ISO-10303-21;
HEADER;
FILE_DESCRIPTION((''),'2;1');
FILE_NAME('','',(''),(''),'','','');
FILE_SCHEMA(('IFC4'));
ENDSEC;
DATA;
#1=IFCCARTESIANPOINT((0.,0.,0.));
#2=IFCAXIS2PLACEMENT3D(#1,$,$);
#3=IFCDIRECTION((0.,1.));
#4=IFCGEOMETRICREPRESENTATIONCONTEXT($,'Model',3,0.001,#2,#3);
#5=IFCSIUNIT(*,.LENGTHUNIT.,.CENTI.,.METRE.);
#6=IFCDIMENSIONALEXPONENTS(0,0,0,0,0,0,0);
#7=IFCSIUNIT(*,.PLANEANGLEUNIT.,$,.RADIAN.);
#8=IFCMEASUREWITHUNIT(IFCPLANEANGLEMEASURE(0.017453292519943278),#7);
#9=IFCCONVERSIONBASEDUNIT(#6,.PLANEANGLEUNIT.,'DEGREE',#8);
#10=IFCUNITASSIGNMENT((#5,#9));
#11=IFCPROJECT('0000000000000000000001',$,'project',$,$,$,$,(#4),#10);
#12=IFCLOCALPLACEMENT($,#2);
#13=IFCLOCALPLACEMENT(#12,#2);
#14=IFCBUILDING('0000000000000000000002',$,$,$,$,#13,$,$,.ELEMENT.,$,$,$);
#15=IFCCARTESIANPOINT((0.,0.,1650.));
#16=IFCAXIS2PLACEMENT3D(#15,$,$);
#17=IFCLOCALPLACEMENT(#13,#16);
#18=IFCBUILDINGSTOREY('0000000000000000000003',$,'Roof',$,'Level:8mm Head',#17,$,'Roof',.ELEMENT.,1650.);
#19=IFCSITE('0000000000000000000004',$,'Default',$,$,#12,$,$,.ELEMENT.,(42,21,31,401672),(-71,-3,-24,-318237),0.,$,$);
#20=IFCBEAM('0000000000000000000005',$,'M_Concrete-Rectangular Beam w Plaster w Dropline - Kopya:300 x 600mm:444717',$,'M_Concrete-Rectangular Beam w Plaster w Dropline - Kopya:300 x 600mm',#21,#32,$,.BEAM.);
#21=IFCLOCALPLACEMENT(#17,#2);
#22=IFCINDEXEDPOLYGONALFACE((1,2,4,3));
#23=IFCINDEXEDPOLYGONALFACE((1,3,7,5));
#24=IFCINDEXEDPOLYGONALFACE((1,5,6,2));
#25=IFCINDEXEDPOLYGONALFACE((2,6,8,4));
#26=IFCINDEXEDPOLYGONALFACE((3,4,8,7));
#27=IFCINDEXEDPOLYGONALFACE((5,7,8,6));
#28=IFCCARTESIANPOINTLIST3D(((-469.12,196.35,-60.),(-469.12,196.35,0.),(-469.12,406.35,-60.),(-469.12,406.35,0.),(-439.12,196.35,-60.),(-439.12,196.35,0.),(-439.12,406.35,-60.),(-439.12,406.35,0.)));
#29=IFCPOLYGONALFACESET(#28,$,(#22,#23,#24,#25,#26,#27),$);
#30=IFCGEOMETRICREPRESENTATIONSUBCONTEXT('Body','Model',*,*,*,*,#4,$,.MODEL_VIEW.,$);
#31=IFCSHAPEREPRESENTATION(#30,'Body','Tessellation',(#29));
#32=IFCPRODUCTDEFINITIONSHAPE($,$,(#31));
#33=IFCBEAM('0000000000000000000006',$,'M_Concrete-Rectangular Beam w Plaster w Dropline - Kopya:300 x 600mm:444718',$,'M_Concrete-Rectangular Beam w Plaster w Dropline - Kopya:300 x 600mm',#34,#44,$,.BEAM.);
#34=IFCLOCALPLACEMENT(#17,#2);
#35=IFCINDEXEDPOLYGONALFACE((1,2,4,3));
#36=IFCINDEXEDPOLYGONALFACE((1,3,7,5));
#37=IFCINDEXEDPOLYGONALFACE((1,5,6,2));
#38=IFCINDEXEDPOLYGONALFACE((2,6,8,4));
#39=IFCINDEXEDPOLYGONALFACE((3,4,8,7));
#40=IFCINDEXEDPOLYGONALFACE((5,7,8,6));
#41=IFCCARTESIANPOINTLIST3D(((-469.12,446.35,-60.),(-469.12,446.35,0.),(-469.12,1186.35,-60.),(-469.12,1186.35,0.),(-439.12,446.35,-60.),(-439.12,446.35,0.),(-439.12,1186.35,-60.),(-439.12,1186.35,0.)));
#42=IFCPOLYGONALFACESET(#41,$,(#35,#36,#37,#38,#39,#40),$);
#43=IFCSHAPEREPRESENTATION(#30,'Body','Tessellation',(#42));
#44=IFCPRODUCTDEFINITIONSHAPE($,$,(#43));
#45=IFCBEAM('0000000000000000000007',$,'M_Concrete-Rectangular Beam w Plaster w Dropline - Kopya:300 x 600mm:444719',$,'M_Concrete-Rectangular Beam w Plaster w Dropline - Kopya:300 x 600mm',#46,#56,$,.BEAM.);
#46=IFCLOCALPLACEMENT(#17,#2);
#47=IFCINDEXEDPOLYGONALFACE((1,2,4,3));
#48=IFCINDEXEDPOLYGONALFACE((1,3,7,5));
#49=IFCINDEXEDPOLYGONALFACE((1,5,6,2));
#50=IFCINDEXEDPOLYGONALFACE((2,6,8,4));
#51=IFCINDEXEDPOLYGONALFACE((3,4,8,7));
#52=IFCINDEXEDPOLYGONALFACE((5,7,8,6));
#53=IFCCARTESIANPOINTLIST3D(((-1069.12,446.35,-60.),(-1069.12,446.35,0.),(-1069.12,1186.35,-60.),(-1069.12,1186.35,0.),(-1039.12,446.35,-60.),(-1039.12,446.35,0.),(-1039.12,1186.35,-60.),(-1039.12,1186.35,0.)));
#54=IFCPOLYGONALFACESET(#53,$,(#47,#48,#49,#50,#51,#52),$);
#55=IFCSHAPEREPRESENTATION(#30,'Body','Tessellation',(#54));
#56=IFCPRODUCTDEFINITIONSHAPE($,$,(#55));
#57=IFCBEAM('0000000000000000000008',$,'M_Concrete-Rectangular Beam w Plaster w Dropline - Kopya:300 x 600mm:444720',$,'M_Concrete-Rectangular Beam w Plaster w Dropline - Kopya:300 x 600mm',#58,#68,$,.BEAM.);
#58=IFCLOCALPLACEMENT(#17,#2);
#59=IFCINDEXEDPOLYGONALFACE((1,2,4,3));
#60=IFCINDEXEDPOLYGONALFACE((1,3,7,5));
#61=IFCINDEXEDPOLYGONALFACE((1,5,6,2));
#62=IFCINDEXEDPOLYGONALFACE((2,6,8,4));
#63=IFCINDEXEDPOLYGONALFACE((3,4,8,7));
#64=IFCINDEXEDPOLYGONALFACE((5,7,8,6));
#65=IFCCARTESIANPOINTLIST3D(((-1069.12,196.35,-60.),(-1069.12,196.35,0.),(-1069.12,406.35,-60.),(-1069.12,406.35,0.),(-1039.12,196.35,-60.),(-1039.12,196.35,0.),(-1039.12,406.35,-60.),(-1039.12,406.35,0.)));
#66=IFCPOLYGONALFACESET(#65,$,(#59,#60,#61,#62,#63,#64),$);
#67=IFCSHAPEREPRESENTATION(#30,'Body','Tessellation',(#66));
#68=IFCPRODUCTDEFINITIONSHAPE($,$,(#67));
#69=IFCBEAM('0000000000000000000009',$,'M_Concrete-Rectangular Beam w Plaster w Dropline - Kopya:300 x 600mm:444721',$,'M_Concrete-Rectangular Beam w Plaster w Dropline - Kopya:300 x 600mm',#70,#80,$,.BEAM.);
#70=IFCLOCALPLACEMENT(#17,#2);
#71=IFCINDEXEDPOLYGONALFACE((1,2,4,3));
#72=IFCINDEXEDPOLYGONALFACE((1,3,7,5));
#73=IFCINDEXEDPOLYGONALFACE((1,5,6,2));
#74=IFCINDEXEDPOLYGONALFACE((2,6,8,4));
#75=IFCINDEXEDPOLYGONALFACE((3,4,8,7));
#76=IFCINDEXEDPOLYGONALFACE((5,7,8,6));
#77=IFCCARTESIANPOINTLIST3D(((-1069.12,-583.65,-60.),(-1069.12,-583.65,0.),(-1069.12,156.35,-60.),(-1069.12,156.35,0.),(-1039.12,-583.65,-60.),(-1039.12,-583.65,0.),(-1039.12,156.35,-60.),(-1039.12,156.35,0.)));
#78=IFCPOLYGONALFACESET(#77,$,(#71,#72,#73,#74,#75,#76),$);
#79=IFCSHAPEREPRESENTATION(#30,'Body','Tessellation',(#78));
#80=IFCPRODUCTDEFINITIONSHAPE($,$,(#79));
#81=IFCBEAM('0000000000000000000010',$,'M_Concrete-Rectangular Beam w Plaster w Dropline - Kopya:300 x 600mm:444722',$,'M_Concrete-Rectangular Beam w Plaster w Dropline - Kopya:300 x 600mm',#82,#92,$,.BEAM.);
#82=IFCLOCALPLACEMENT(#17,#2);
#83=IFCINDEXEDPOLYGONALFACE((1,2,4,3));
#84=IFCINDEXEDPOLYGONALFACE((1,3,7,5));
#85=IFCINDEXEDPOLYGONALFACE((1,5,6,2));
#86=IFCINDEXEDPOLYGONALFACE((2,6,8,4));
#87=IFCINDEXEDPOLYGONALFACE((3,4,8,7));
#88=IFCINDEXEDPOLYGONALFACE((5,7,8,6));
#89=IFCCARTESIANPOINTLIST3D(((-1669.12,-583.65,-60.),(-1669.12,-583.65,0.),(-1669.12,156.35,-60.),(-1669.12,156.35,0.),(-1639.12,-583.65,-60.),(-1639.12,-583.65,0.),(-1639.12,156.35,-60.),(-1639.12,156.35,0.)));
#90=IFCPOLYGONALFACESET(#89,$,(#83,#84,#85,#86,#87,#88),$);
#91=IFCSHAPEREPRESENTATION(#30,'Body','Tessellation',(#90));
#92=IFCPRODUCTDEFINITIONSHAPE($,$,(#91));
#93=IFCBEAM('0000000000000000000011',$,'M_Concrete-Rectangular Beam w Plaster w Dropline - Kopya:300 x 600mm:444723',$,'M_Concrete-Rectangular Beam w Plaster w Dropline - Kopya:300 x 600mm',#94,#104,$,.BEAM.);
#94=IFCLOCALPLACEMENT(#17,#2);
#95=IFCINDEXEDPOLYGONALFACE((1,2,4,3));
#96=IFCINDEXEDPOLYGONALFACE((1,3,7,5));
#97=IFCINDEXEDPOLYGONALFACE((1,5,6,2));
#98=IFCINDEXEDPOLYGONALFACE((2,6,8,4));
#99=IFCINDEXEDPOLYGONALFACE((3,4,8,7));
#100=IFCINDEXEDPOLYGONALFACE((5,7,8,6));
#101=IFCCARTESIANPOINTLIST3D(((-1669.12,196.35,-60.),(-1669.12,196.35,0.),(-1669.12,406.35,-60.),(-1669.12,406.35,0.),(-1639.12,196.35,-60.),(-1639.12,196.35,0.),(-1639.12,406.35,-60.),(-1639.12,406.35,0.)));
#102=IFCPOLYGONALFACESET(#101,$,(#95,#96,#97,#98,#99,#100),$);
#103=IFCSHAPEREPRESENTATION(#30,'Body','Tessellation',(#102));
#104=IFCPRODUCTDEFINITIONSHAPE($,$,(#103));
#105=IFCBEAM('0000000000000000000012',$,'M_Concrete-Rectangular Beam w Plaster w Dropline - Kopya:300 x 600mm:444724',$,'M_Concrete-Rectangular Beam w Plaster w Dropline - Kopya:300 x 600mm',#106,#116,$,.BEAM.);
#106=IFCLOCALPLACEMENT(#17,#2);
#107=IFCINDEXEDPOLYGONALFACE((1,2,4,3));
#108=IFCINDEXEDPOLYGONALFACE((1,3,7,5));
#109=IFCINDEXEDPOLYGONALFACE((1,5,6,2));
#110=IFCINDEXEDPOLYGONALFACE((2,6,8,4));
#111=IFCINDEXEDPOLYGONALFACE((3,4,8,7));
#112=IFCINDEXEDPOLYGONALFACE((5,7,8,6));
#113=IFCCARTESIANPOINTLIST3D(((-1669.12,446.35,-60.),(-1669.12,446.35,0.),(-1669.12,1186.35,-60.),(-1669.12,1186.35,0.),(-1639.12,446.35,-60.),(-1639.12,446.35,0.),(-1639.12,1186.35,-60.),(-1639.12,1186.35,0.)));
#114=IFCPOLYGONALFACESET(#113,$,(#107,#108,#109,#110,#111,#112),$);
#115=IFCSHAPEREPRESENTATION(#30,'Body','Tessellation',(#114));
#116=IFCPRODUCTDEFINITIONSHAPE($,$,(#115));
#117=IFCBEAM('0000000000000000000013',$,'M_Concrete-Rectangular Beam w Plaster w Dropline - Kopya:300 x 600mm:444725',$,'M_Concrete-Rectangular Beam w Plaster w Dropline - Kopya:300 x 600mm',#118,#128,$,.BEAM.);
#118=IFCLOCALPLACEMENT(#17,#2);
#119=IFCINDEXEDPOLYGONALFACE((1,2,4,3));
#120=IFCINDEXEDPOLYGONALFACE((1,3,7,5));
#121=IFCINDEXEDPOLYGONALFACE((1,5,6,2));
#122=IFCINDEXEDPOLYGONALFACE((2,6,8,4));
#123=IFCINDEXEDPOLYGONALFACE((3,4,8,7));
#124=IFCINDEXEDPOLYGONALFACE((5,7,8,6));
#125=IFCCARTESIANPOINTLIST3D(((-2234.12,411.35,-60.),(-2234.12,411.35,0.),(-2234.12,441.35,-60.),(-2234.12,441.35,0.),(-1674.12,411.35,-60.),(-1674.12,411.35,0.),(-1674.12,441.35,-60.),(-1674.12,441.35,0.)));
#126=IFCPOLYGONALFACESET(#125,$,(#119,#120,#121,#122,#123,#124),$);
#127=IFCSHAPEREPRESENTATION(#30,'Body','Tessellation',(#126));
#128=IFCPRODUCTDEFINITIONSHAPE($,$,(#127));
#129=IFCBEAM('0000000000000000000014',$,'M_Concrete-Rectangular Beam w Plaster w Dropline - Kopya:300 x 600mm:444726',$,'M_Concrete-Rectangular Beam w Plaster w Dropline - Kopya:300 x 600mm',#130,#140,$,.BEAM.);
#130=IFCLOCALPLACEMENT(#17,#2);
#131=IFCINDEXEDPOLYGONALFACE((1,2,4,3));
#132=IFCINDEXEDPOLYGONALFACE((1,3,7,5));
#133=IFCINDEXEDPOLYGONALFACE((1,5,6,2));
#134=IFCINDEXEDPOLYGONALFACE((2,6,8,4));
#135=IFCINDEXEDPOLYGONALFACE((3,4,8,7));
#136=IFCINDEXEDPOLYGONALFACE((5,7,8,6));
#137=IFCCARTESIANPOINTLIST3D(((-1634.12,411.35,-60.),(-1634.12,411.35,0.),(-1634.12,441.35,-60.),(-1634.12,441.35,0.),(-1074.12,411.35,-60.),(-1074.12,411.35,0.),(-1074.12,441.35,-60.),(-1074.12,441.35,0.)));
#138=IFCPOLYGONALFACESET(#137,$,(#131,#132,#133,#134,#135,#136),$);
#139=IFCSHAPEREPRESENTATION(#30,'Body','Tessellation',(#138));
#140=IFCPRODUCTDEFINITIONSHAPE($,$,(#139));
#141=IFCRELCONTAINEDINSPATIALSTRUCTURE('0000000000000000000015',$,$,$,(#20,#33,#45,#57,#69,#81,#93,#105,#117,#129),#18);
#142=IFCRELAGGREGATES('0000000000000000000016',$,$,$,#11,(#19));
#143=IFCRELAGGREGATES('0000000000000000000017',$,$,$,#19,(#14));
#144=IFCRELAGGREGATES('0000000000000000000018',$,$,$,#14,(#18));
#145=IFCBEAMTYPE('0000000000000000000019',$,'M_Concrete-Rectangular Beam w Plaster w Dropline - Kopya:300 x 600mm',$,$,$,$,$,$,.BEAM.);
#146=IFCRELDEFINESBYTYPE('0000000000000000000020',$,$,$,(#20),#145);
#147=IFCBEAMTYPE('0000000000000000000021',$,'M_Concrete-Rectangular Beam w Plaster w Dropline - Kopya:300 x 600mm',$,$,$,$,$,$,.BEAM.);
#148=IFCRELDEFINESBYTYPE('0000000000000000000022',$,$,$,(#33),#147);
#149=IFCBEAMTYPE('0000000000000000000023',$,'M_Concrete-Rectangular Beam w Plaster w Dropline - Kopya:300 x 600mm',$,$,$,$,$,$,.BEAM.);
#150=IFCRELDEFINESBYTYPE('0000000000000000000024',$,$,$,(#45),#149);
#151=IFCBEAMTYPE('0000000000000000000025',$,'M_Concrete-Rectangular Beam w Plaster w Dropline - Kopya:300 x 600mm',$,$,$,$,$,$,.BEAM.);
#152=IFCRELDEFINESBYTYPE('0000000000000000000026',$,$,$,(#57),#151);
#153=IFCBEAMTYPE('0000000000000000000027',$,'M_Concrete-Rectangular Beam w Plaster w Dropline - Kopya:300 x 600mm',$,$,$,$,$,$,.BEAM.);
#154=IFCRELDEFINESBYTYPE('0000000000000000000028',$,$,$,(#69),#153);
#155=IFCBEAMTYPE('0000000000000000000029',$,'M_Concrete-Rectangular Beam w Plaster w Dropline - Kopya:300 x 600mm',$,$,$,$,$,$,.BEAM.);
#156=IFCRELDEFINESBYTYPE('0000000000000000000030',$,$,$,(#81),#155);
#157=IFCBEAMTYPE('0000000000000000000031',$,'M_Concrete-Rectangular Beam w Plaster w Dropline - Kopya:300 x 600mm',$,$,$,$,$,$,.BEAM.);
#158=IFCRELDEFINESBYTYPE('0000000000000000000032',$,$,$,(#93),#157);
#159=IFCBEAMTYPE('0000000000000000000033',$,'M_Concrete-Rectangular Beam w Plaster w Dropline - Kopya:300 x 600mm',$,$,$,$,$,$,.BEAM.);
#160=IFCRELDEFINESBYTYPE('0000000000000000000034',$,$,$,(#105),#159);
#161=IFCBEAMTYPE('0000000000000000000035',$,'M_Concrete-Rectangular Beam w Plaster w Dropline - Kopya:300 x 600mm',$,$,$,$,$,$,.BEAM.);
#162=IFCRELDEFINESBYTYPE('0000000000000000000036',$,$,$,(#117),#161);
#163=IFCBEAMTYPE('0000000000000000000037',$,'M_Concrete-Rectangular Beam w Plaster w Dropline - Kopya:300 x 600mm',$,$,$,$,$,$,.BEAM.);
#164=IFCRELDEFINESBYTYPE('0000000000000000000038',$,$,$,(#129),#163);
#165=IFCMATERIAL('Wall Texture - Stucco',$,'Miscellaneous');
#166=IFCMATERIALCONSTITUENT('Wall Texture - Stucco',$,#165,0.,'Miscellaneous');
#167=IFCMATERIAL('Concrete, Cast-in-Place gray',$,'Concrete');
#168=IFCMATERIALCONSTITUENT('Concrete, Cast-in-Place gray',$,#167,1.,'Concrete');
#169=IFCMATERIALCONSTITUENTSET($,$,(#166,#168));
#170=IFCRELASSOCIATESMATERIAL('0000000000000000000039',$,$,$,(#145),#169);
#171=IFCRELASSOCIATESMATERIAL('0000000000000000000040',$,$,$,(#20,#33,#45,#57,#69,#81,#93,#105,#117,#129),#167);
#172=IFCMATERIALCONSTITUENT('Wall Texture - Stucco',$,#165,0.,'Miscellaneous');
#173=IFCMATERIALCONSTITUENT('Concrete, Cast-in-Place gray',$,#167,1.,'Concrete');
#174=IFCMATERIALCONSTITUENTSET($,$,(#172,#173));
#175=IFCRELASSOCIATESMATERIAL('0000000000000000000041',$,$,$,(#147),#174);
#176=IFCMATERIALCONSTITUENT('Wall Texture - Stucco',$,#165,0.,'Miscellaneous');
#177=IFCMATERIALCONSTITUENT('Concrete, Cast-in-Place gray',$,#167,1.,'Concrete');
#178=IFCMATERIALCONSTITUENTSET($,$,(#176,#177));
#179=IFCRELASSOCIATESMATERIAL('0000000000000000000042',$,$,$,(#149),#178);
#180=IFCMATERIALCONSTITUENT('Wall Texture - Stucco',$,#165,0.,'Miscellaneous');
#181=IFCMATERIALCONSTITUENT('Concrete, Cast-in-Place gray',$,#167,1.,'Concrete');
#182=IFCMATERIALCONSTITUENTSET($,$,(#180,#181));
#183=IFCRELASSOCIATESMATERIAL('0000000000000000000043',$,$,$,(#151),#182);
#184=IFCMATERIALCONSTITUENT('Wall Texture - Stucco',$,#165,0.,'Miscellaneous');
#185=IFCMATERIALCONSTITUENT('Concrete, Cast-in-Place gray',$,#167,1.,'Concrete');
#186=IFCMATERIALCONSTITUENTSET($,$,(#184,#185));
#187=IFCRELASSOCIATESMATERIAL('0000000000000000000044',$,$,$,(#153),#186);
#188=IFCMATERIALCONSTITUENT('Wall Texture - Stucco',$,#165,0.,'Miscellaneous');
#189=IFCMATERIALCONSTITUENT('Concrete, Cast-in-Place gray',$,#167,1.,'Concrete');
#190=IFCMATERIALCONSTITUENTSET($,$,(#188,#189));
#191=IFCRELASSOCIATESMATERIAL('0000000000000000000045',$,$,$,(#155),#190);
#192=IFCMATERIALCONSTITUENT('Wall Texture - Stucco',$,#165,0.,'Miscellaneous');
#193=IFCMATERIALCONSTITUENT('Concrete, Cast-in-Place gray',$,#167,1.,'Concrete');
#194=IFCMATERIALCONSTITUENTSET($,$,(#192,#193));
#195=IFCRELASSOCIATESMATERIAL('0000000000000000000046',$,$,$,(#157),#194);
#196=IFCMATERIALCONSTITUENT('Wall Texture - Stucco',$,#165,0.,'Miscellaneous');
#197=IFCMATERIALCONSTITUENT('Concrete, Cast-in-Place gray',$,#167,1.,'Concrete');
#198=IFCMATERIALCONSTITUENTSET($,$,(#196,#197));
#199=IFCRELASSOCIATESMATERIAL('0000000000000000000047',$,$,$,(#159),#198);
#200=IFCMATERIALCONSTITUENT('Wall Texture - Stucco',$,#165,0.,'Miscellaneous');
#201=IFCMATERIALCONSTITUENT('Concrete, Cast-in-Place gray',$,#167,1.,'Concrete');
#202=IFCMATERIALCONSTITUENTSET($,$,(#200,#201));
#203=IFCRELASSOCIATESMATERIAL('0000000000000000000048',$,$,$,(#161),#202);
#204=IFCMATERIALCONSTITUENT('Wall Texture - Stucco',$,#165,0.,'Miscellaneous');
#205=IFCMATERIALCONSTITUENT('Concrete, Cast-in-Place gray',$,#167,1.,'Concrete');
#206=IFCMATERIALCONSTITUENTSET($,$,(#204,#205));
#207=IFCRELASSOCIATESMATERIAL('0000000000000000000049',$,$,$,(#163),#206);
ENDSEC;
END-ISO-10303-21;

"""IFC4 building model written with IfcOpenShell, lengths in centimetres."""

from ifc_helpers import new_model, entity, si_unit, converted_unit, direction, frame, origin, place, context, subcontext, project, spatial, indexed_curve, outline, extrude, source, transform, mapped, material, constituent, constituent_set, type_object, type_shapes, element, save


model = new_model("IFC4")

# Units and contexts
model_context = context("Model", 3, precision=0.001, world=origin(), true_north=direction((0.0, 1.0)))
body_context = subcontext(model_context, "Body", "Model", "MODEL_VIEW")
ifc_project = project(units=[si_unit("LENGTHUNIT", "METRE", prefix="CENTI"), converted_unit("PLANEANGLEUNIT", "DEGREE", entity("IfcPlaneAngleMeasure", 0.017453292519943278), si_unit("PLANEANGLEUNIT", "RADIAN"), dimensions=[0, 0, 0, 0, 0, 0, 0])], contexts=[model_context])

# Site, building, storey
site_placement = place(None, origin())
site = spatial("IfcSite", under=ifc_project, at=site_placement, Name="Default", CompositionType="ELEMENT", RefLatitude=(42, 21, 31, 401672), RefLongitude=(-71, -3, -24, -318237), RefElevation=0.0)
building_placement = place(site_placement, origin())
building = spatial("IfcBuilding", under=site, at=building_placement, CompositionType="ELEMENT")
storey_placement = place(building_placement, frame((0.0, 0.0, 1650.0)))
storey = spatial("IfcBuildingStorey", under=building, at=storey_placement, Name="Roof", ObjectType="Level:8mm Head", LongName="Roof", CompositionType="ELEMENT", Elevation=1650.0)

# Beams
ifc_material_1 = material(Name="Concrete, Cast-in-Place gray", Category="Concrete")
ifc_material_2 = material(Name="Wall Texture - Stucco", Category="Miscellaneous")
ifc_constituent_1 = constituent(ifc_material_2, Name="Wall Texture - Stucco", Category="Miscellaneous", fraction=0.0)
ifc_constituent_2 = constituent(ifc_material_1, Name="Concrete, Cast-in-Place gray", Category="Concrete", fraction=1.0)
ifc_constituent_set_1 = constituent_set(constituents=[ifc_constituent_1, ifc_constituent_2])
beam_type_1 = type_object("IfcBeamType", Name="M_Concrete-Rectangular Beam w Plaster w Dropline - Kopya:300 x 600mm", PredefinedType="BEAM", material=ifc_constituent_set_1)
shared_shape_1 = source(origin(), body_context, "Body", "SweptSolid", [
    extrude(outline(indexed_curve([(-15.0, -30.0), (15.0, -30.0), (15.0, 30.0), (-15.0, 30.0), (-15.0, -30.0)], self_intersect=False)), frame((-454.12, 196.35, 1620.0), z_axis=(0.0, 1.0, 0.0), x_axis=(-1.0, 0.0, 0.0)), (0.0, 0.0, 1.0), 210.0),
])
type_shapes(beam_type_1, [shared_shape_1])
beam_1_placement = place(storey_placement, frame((0.0, 0.0, -1650.0)))
element("IfcBeam", 1, at=beam_1_placement, inside=storey, type_object=beam_type_1, material=ifc_material_1, Name="M_Concrete-Rectangular Beam w Plaster w Dropline - Kopya:300 x 600mm:444717", ObjectType="M_Concrete-Rectangular Beam w Plaster w Dropline - Kopya:300 x 600mm", PredefinedType="BEAM", context=body_context, shape_type="MappedRepresentation", body=[
    mapped(shared_shape_1, transform((0.0, 0.0, 0.0), scale=1.0)),
])
ifc_constituent_3 = constituent(ifc_material_2, Name="Wall Texture - Stucco", Category="Miscellaneous", fraction=0.0)
ifc_constituent_4 = constituent(ifc_material_1, Name="Concrete, Cast-in-Place gray", Category="Concrete", fraction=1.0)
ifc_constituent_set_2 = constituent_set(constituents=[ifc_constituent_3, ifc_constituent_4])
beam_type_2 = type_object("IfcBeamType", Name="M_Concrete-Rectangular Beam w Plaster w Dropline - Kopya:300 x 600mm", PredefinedType="BEAM", material=ifc_constituent_set_2)
shared_shape_2 = source(origin(), body_context, "Body", "SweptSolid", [
    extrude(outline(indexed_curve([(-15.0, -30.0), (15.0, -30.0), (15.0, 30.0), (-15.0, 30.0), (-15.0, -30.0)], self_intersect=False)), frame((-454.12, 446.35, 1620.0), z_axis=(0.0, 1.0, 0.0), x_axis=(-1.0, 0.0, 0.0)), (0.0, 0.0, 1.0), 740.0),
])
type_shapes(beam_type_2, [shared_shape_2])
beam_2_placement = place(storey_placement, frame((0.0, 0.0, -1650.0)))
element("IfcBeam", 2, at=beam_2_placement, inside=storey, type_object=beam_type_2, material=ifc_material_1, Name="M_Concrete-Rectangular Beam w Plaster w Dropline - Kopya:300 x 600mm:444718", ObjectType="M_Concrete-Rectangular Beam w Plaster w Dropline - Kopya:300 x 600mm", PredefinedType="BEAM", context=body_context, shape_type="MappedRepresentation", body=[
    mapped(shared_shape_2, transform((0.0, 0.0, 0.0), scale=1.0)),
])
ifc_constituent_5 = constituent(ifc_material_2, Name="Wall Texture - Stucco", Category="Miscellaneous", fraction=0.0)
ifc_constituent_6 = constituent(ifc_material_1, Name="Concrete, Cast-in-Place gray", Category="Concrete", fraction=1.0)
ifc_constituent_set_3 = constituent_set(constituents=[ifc_constituent_5, ifc_constituent_6])
beam_type_3 = type_object("IfcBeamType", Name="M_Concrete-Rectangular Beam w Plaster w Dropline - Kopya:300 x 600mm", PredefinedType="BEAM", material=ifc_constituent_set_3)
shared_shape_3 = source(origin(), body_context, "Body", "SweptSolid", [
    extrude(outline(indexed_curve([(-15.0, -30.0), (15.0, -30.0), (15.0, 30.0), (-15.0, 30.0), (-15.0, -30.0)], self_intersect=False)), frame((-1054.12, 1186.35, 1620.0), z_axis=(0.0, -1.0, 0.0), x_axis=(-1.0, 0.0, 0.0)), (0.0, 0.0, 1.0), 740.0),
])
type_shapes(beam_type_3, [shared_shape_3])
beam_3_placement = place(storey_placement, frame((0.0, 0.0, -1650.0)))
element("IfcBeam", 3, at=beam_3_placement, inside=storey, type_object=beam_type_3, material=ifc_material_1, Name="M_Concrete-Rectangular Beam w Plaster w Dropline - Kopya:300 x 600mm:444719", ObjectType="M_Concrete-Rectangular Beam w Plaster w Dropline - Kopya:300 x 600mm", PredefinedType="BEAM", context=body_context, shape_type="MappedRepresentation", body=[
    mapped(shared_shape_3, transform((0.0, 0.0, 0.0), scale=1.0)),
])
ifc_constituent_7 = constituent(ifc_material_2, Name="Wall Texture - Stucco", Category="Miscellaneous", fraction=0.0)
ifc_constituent_8 = constituent(ifc_material_1, Name="Concrete, Cast-in-Place gray", Category="Concrete", fraction=1.0)
ifc_constituent_set_4 = constituent_set(constituents=[ifc_constituent_7, ifc_constituent_8])
beam_type_4 = type_object("IfcBeamType", Name="M_Concrete-Rectangular Beam w Plaster w Dropline - Kopya:300 x 600mm", PredefinedType="BEAM", material=ifc_constituent_set_4)
shared_shape_4 = source(origin(), body_context, "Body", "SweptSolid", [
    extrude(outline(indexed_curve([(-15.0, -30.0), (15.0, -30.0), (15.0, 30.0), (-15.0, 30.0), (-15.0, -30.0)], self_intersect=False)), frame((-1054.12, 406.35, 1620.0), z_axis=(0.0, -1.0, 0.0), x_axis=(-1.0, 0.0, 0.0)), (0.0, 0.0, 1.0), 210.0),
])
type_shapes(beam_type_4, [shared_shape_4])
beam_4_placement = place(storey_placement, frame((0.0, 0.0, -1650.0)))
element("IfcBeam", 4, at=beam_4_placement, inside=storey, type_object=beam_type_4, material=ifc_material_1, Name="M_Concrete-Rectangular Beam w Plaster w Dropline - Kopya:300 x 600mm:444720", ObjectType="M_Concrete-Rectangular Beam w Plaster w Dropline - Kopya:300 x 600mm", PredefinedType="BEAM", context=body_context, shape_type="MappedRepresentation", body=[
    mapped(shared_shape_4, transform((0.0, 0.0, 0.0), scale=1.0)),
])
ifc_constituent_9 = constituent(ifc_material_2, Name="Wall Texture - Stucco", Category="Miscellaneous", fraction=0.0)
ifc_constituent_10 = constituent(ifc_material_1, Name="Concrete, Cast-in-Place gray", Category="Concrete", fraction=1.0)
ifc_constituent_set_5 = constituent_set(constituents=[ifc_constituent_9, ifc_constituent_10])
beam_type_5 = type_object("IfcBeamType", Name="M_Concrete-Rectangular Beam w Plaster w Dropline - Kopya:300 x 600mm", PredefinedType="BEAM", material=ifc_constituent_set_5)
shared_shape_5 = source(origin(), body_context, "Body", "SweptSolid", [
    extrude(outline(indexed_curve([(-15.0, -30.0), (15.0, -30.0), (15.0, 30.0), (-15.0, 30.0), (-15.0, -30.0)], self_intersect=False)), frame((-1054.12, 156.35, 1620.0), z_axis=(0.0, -1.0, 0.0), x_axis=(-1.0, 0.0, 0.0)), (0.0, 0.0, 1.0), 740.0),
])
type_shapes(beam_type_5, [shared_shape_5])
beam_5_placement = place(storey_placement, frame((0.0, 0.0, -1650.0)))
element("IfcBeam", 5, at=beam_5_placement, inside=storey, type_object=beam_type_5, material=ifc_material_1, Name="M_Concrete-Rectangular Beam w Plaster w Dropline - Kopya:300 x 600mm:444721", ObjectType="M_Concrete-Rectangular Beam w Plaster w Dropline - Kopya:300 x 600mm", PredefinedType="BEAM", context=body_context, shape_type="MappedRepresentation", body=[
    mapped(shared_shape_5, transform((0.0, 0.0, 0.0), scale=1.0)),
])
ifc_constituent_11 = constituent(ifc_material_2, Name="Wall Texture - Stucco", Category="Miscellaneous", fraction=0.0)
ifc_constituent_12 = constituent(ifc_material_1, Name="Concrete, Cast-in-Place gray", Category="Concrete", fraction=1.0)
ifc_constituent_set_6 = constituent_set(constituents=[ifc_constituent_11, ifc_constituent_12])
beam_type_6 = type_object("IfcBeamType", Name="M_Concrete-Rectangular Beam w Plaster w Dropline - Kopya:300 x 600mm", PredefinedType="BEAM", material=ifc_constituent_set_6)
shared_shape_6 = source(origin(), body_context, "Body", "SweptSolid", [
    extrude(outline(indexed_curve([(-15.0, -30.0), (15.0, -30.0), (15.0, 30.0), (-15.0, 30.0), (-15.0, -30.0)], self_intersect=False)), frame((-1654.12, -583.65, 1620.0), z_axis=(0.0, 1.0, 0.0), x_axis=(-1.0, 0.0, 0.0)), (0.0, 0.0, 1.0), 740.0),
])
type_shapes(beam_type_6, [shared_shape_6])
beam_6_placement = place(storey_placement, frame((0.0, 0.0, -1650.0)))
element("IfcBeam", 6, at=beam_6_placement, inside=storey, type_object=beam_type_6, material=ifc_material_1, Name="M_Concrete-Rectangular Beam w Plaster w Dropline - Kopya:300 x 600mm:444722", ObjectType="M_Concrete-Rectangular Beam w Plaster w Dropline - Kopya:300 x 600mm", PredefinedType="BEAM", context=body_context, shape_type="MappedRepresentation", body=[
    mapped(shared_shape_6, transform((0.0, 0.0, 0.0), scale=1.0)),
])
ifc_constituent_13 = constituent(ifc_material_2, Name="Wall Texture - Stucco", Category="Miscellaneous", fraction=0.0)
ifc_constituent_14 = constituent(ifc_material_1, Name="Concrete, Cast-in-Place gray", Category="Concrete", fraction=1.0)
ifc_constituent_set_7 = constituent_set(constituents=[ifc_constituent_13, ifc_constituent_14])
beam_type_7 = type_object("IfcBeamType", Name="M_Concrete-Rectangular Beam w Plaster w Dropline - Kopya:300 x 600mm", PredefinedType="BEAM", material=ifc_constituent_set_7)
shared_shape_7 = source(origin(), body_context, "Body", "SweptSolid", [
    extrude(outline(indexed_curve([(-15.0, -30.0), (15.0, -30.0), (15.0, 30.0), (-15.0, 30.0), (-15.0, -30.0)], self_intersect=False)), frame((-1654.12, 196.35, 1620.0), z_axis=(0.0, 1.0, 0.0), x_axis=(-1.0, 0.0, 0.0)), (0.0, 0.0, 1.0), 210.0),
])
type_shapes(beam_type_7, [shared_shape_7])
beam_7_placement = place(storey_placement, frame((0.0, 0.0, -1650.0)))
element("IfcBeam", 7, at=beam_7_placement, inside=storey, type_object=beam_type_7, material=ifc_material_1, Name="M_Concrete-Rectangular Beam w Plaster w Dropline - Kopya:300 x 600mm:444723", ObjectType="M_Concrete-Rectangular Beam w Plaster w Dropline - Kopya:300 x 600mm", PredefinedType="BEAM", context=body_context, shape_type="MappedRepresentation", body=[
    mapped(shared_shape_7, transform((0.0, 0.0, 0.0), scale=1.0)),
])
ifc_constituent_15 = constituent(ifc_material_2, Name="Wall Texture - Stucco", Category="Miscellaneous", fraction=0.0)
ifc_constituent_16 = constituent(ifc_material_1, Name="Concrete, Cast-in-Place gray", Category="Concrete", fraction=1.0)
ifc_constituent_set_8 = constituent_set(constituents=[ifc_constituent_15, ifc_constituent_16])
beam_type_8 = type_object("IfcBeamType", Name="M_Concrete-Rectangular Beam w Plaster w Dropline - Kopya:300 x 600mm", PredefinedType="BEAM", material=ifc_constituent_set_8)
shared_shape_8 = source(origin(), body_context, "Body", "SweptSolid", [
    extrude(outline(indexed_curve([(-15.0, -30.0), (15.0, -30.0), (15.0, 30.0), (-15.0, 30.0), (-15.0, -30.0)], self_intersect=False)), frame((-1654.12, 446.35, 1620.0), z_axis=(0.0, 1.0, 0.0), x_axis=(-1.0, 0.0, 0.0)), (0.0, 0.0, 1.0), 740.0),
])
type_shapes(beam_type_8, [shared_shape_8])
beam_8_placement = place(storey_placement, frame((0.0, 0.0, -1650.0)))
element("IfcBeam", 8, at=beam_8_placement, inside=storey, type_object=beam_type_8, material=ifc_material_1, Name="M_Concrete-Rectangular Beam w Plaster w Dropline - Kopya:300 x 600mm:444724", ObjectType="M_Concrete-Rectangular Beam w Plaster w Dropline - Kopya:300 x 600mm", PredefinedType="BEAM", context=body_context, shape_type="MappedRepresentation", body=[
    mapped(shared_shape_8, transform((0.0, 0.0, 0.0), scale=1.0)),
])
ifc_constituent_17 = constituent(ifc_material_2, Name="Wall Texture - Stucco", Category="Miscellaneous", fraction=0.0)
ifc_constituent_18 = constituent(ifc_material_1, Name="Concrete, Cast-in-Place gray", Category="Concrete", fraction=1.0)
ifc_constituent_set_9 = constituent_set(constituents=[ifc_constituent_17, ifc_constituent_18])
beam_type_9 = type_object("IfcBeamType", Name="M_Concrete-Rectangular Beam w Plaster w Dropline - Kopya:300 x 600mm", PredefinedType="BEAM", material=ifc_constituent_set_9)
shared_shape_9 = source(origin(), body_context, "Body", "SweptSolid", [
    extrude(outline(indexed_curve([(-30.0, -15.0), (30.0, -15.0), (30.0, 15.0), (-30.0, 15.0), (-30.0, -15.0)], self_intersect=False)), frame((-2234.12, 426.35, 1620.0), z_axis=(1.0, 0.0, 0.0), x_axis=(0.0, 0.0, -1.0)), (0.0, 0.0, 1.0), 560.0),
])
type_shapes(beam_type_9, [shared_shape_9])
beam_9_placement = place(storey_placement, frame((0.0, 0.0, -1650.0)))
element("IfcBeam", 9, at=beam_9_placement, inside=storey, type_object=beam_type_9, material=ifc_material_1, Name="M_Concrete-Rectangular Beam w Plaster w Dropline - Kopya:300 x 600mm:444725", ObjectType="M_Concrete-Rectangular Beam w Plaster w Dropline - Kopya:300 x 600mm", PredefinedType="BEAM", context=body_context, shape_type="MappedRepresentation", body=[
    mapped(shared_shape_9, transform((0.0, 0.0, 0.0), scale=1.0)),
])
ifc_constituent_19 = constituent(ifc_material_2, Name="Wall Texture - Stucco", Category="Miscellaneous", fraction=0.0)
ifc_constituent_20 = constituent(ifc_material_1, Name="Concrete, Cast-in-Place gray", Category="Concrete", fraction=1.0)
ifc_constituent_set_10 = constituent_set(constituents=[ifc_constituent_19, ifc_constituent_20])
beam_type_10 = type_object("IfcBeamType", Name="M_Concrete-Rectangular Beam w Plaster w Dropline - Kopya:300 x 600mm", PredefinedType="BEAM", material=ifc_constituent_set_10)
shared_shape_10 = source(origin(), body_context, "Body", "SweptSolid", [
    extrude(outline(indexed_curve([(-30.0, -15.0), (30.0, -15.0), (30.0, 15.0), (-30.0, 15.0), (-30.0, -15.0)], self_intersect=False)), frame((-1634.12, 426.35, 1620.0), z_axis=(1.0, 0.0, 0.0), x_axis=(0.0, 0.0, -1.0)), (0.0, 0.0, 1.0), 560.0),
])
type_shapes(beam_type_10, [shared_shape_10])
beam_10_placement = place(storey_placement, frame((0.0, 0.0, -1650.0)))
element("IfcBeam", 10, at=beam_10_placement, inside=storey, type_object=beam_type_10, material=ifc_material_1, Name="M_Concrete-Rectangular Beam w Plaster w Dropline - Kopya:300 x 600mm:444726", ObjectType="M_Concrete-Rectangular Beam w Plaster w Dropline - Kopya:300 x 600mm", PredefinedType="BEAM", context=body_context, shape_type="MappedRepresentation", body=[
    mapped(shared_shape_10, transform((0.0, 0.0, 0.0), scale=1.0)),
])

save(model, "model.ifc")
